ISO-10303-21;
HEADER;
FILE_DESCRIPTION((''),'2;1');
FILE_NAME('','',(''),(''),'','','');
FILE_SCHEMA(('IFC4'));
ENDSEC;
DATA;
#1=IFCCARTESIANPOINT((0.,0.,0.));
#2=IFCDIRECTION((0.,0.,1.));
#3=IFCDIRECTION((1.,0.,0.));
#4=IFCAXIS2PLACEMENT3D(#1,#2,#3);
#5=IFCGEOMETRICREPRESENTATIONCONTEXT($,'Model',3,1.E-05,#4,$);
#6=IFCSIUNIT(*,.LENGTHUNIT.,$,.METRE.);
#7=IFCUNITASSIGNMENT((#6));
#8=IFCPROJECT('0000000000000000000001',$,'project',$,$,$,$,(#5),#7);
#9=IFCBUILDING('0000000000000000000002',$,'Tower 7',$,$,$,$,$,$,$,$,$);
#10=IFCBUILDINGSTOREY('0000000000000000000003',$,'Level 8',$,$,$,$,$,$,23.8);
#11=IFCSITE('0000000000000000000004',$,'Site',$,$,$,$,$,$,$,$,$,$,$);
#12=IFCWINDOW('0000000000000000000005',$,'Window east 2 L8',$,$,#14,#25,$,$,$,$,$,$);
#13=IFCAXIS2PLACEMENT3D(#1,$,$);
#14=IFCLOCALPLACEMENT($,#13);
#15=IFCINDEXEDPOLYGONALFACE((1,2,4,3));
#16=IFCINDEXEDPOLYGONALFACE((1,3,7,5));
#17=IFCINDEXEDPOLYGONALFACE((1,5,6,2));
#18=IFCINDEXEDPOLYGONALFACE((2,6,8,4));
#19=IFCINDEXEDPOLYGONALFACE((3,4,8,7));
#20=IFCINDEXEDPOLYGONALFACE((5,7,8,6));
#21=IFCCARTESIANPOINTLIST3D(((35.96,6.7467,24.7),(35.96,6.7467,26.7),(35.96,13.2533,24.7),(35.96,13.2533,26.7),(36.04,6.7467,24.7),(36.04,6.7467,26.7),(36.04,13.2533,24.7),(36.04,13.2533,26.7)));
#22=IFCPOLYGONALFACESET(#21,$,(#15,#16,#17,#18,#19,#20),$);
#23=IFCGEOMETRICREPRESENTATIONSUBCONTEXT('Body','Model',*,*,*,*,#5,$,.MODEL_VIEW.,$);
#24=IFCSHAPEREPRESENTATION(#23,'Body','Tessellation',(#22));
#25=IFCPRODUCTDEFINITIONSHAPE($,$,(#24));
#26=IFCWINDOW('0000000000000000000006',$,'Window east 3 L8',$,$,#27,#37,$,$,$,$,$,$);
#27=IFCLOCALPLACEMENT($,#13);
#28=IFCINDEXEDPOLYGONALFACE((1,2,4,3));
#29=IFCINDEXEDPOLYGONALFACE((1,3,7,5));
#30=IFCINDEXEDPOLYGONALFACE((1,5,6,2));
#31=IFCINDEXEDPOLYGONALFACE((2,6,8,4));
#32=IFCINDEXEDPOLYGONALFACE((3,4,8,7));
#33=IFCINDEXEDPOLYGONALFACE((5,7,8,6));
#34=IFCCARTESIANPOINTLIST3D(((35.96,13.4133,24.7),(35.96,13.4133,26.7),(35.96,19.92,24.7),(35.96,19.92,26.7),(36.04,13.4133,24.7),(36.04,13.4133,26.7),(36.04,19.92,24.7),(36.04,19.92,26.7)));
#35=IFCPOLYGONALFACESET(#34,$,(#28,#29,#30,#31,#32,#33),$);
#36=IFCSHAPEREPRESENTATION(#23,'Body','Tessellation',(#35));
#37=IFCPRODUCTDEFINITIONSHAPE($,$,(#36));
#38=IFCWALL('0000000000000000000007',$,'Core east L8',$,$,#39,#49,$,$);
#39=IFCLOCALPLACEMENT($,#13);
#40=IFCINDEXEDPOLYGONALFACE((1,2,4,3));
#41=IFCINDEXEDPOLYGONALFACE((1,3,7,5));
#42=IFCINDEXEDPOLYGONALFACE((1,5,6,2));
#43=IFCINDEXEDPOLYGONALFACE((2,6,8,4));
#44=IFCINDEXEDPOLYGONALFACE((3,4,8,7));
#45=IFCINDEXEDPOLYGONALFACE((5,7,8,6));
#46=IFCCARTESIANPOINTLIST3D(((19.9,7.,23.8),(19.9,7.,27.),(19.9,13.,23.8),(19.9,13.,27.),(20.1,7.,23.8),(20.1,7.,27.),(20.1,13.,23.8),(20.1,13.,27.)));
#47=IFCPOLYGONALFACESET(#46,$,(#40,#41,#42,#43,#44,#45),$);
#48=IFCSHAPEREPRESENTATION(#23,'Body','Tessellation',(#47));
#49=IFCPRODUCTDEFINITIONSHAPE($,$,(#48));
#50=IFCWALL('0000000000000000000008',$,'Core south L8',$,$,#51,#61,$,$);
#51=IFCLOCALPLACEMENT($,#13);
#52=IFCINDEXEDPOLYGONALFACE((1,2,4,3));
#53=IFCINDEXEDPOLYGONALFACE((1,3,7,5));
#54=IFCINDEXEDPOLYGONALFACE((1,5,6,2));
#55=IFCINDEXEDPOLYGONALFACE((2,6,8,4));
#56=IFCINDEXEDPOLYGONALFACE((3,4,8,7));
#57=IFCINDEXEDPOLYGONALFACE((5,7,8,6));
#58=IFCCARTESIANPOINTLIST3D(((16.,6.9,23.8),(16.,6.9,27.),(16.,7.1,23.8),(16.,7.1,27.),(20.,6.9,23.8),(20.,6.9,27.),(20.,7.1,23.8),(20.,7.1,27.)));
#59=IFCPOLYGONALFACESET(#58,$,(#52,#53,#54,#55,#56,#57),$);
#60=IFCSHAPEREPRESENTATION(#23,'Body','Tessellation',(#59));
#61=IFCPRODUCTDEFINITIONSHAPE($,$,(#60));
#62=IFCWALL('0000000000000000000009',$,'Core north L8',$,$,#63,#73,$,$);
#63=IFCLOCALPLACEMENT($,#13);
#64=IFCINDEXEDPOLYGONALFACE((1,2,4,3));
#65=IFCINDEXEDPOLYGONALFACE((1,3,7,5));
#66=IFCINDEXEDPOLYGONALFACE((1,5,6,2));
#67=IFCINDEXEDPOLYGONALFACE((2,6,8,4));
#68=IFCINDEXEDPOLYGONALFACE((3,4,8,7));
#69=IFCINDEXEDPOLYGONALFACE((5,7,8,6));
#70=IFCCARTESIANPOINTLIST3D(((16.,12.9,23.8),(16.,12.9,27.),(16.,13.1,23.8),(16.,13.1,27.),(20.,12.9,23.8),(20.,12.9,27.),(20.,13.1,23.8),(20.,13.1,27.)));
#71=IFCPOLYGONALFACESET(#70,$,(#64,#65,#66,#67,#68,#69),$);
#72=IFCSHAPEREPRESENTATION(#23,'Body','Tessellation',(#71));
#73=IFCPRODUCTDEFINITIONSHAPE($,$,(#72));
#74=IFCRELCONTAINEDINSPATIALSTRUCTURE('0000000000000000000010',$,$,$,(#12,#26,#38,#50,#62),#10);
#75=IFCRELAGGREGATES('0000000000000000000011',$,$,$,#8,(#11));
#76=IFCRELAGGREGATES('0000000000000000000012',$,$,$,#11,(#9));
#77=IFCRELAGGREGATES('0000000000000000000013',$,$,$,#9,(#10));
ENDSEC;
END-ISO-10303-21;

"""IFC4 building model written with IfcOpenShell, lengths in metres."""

from ifc_helpers import new_model, si_unit, frame, origin, origin_with_axes, origin_2d, place, context, subcontext, project, spatial, rectangle, extrude, element, save


model = new_model("IFC4")

# Units and contexts
model_context = context("Model", 3, precision=1e-05, world=origin_with_axes())
body_context = subcontext(model_context, "Body", "Model", "MODEL_VIEW")
ifc_project = project(units=[si_unit("LENGTHUNIT", "METRE")], contexts=[model_context])

# Site, building, storey
site = spatial("IfcSite", under=ifc_project, Name="Site")
building = spatial("IfcBuilding", under=site, Name="Tower 7")
storey = spatial("IfcBuildingStorey", under=building, Name="Level 8", Elevation=23.8)

# Windows
for number, where, z_axis, x_axis, name in (
    (1, (36.0, 10.0, 24.7), (0.0, 0.0, 1.0), (1.0, 0.0, 0.0), "Window east 2 L8"),
):
    element("IfcWindow", number, at=place(None, frame(where, z_axis=z_axis, x_axis=x_axis)), inside=storey, Name=name, context=body_context, shape_type="SweptSolid", body=[
        extrude(rectangle(XDim=0.08, YDim=6.5067, at=origin_2d()), origin(), (0.0, 0.0, 1.0), 2.0),
    ])
window_placement = place(None, frame((36.0, 16.6667, 24.7), z_axis=(0.0, 0.0, 1.0), x_axis=(1.0, 0.0, 0.0)))
element("IfcWindow", 2, at=window_placement, inside=storey, Name="Window east 3 L8", context=body_context, shape_type="SweptSolid", body=[
    extrude(rectangle(XDim=0.08, YDim=6.5067, at=origin_2d()), origin(), (0.0, 0.0, 1.0), 2.0),
])

# Walls
wall_1_placement = place(None, frame((20.0, 10.0, 23.8), z_axis=(0.0, 0.0, 1.0), x_axis=(1.0, 0.0, 0.0)))
element("IfcWall", 3, at=wall_1_placement, inside=storey, Name="Core east L8", context=body_context, shape_type="SweptSolid", body=[
    extrude(rectangle(XDim=0.2, YDim=6.0, at=origin_2d()), origin(), (0.0, 0.0, 1.0), 3.2),
])
for number, where, z_axis, x_axis, name in (
    (4, (18.0, 7.0, 23.8), (0.0, 0.0, 1.0), (1.0, 0.0, 0.0), "Core south L8"),
    (5, (18.0, 13.0, 23.8), (0.0, 0.0, 1.0), (1.0, 0.0, 0.0), "Core north L8"),
):
    element("IfcWall", number, at=place(None, frame(where, z_axis=z_axis, x_axis=x_axis)), inside=storey, Name=name, context=body_context, shape_type="SweptSolid", body=[
        extrude(rectangle(XDim=4.0, YDim=0.2, at=origin_2d()), origin(), (0.0, 0.0, 1.0), 3.2),
    ])

save(model, "model.ifc")
